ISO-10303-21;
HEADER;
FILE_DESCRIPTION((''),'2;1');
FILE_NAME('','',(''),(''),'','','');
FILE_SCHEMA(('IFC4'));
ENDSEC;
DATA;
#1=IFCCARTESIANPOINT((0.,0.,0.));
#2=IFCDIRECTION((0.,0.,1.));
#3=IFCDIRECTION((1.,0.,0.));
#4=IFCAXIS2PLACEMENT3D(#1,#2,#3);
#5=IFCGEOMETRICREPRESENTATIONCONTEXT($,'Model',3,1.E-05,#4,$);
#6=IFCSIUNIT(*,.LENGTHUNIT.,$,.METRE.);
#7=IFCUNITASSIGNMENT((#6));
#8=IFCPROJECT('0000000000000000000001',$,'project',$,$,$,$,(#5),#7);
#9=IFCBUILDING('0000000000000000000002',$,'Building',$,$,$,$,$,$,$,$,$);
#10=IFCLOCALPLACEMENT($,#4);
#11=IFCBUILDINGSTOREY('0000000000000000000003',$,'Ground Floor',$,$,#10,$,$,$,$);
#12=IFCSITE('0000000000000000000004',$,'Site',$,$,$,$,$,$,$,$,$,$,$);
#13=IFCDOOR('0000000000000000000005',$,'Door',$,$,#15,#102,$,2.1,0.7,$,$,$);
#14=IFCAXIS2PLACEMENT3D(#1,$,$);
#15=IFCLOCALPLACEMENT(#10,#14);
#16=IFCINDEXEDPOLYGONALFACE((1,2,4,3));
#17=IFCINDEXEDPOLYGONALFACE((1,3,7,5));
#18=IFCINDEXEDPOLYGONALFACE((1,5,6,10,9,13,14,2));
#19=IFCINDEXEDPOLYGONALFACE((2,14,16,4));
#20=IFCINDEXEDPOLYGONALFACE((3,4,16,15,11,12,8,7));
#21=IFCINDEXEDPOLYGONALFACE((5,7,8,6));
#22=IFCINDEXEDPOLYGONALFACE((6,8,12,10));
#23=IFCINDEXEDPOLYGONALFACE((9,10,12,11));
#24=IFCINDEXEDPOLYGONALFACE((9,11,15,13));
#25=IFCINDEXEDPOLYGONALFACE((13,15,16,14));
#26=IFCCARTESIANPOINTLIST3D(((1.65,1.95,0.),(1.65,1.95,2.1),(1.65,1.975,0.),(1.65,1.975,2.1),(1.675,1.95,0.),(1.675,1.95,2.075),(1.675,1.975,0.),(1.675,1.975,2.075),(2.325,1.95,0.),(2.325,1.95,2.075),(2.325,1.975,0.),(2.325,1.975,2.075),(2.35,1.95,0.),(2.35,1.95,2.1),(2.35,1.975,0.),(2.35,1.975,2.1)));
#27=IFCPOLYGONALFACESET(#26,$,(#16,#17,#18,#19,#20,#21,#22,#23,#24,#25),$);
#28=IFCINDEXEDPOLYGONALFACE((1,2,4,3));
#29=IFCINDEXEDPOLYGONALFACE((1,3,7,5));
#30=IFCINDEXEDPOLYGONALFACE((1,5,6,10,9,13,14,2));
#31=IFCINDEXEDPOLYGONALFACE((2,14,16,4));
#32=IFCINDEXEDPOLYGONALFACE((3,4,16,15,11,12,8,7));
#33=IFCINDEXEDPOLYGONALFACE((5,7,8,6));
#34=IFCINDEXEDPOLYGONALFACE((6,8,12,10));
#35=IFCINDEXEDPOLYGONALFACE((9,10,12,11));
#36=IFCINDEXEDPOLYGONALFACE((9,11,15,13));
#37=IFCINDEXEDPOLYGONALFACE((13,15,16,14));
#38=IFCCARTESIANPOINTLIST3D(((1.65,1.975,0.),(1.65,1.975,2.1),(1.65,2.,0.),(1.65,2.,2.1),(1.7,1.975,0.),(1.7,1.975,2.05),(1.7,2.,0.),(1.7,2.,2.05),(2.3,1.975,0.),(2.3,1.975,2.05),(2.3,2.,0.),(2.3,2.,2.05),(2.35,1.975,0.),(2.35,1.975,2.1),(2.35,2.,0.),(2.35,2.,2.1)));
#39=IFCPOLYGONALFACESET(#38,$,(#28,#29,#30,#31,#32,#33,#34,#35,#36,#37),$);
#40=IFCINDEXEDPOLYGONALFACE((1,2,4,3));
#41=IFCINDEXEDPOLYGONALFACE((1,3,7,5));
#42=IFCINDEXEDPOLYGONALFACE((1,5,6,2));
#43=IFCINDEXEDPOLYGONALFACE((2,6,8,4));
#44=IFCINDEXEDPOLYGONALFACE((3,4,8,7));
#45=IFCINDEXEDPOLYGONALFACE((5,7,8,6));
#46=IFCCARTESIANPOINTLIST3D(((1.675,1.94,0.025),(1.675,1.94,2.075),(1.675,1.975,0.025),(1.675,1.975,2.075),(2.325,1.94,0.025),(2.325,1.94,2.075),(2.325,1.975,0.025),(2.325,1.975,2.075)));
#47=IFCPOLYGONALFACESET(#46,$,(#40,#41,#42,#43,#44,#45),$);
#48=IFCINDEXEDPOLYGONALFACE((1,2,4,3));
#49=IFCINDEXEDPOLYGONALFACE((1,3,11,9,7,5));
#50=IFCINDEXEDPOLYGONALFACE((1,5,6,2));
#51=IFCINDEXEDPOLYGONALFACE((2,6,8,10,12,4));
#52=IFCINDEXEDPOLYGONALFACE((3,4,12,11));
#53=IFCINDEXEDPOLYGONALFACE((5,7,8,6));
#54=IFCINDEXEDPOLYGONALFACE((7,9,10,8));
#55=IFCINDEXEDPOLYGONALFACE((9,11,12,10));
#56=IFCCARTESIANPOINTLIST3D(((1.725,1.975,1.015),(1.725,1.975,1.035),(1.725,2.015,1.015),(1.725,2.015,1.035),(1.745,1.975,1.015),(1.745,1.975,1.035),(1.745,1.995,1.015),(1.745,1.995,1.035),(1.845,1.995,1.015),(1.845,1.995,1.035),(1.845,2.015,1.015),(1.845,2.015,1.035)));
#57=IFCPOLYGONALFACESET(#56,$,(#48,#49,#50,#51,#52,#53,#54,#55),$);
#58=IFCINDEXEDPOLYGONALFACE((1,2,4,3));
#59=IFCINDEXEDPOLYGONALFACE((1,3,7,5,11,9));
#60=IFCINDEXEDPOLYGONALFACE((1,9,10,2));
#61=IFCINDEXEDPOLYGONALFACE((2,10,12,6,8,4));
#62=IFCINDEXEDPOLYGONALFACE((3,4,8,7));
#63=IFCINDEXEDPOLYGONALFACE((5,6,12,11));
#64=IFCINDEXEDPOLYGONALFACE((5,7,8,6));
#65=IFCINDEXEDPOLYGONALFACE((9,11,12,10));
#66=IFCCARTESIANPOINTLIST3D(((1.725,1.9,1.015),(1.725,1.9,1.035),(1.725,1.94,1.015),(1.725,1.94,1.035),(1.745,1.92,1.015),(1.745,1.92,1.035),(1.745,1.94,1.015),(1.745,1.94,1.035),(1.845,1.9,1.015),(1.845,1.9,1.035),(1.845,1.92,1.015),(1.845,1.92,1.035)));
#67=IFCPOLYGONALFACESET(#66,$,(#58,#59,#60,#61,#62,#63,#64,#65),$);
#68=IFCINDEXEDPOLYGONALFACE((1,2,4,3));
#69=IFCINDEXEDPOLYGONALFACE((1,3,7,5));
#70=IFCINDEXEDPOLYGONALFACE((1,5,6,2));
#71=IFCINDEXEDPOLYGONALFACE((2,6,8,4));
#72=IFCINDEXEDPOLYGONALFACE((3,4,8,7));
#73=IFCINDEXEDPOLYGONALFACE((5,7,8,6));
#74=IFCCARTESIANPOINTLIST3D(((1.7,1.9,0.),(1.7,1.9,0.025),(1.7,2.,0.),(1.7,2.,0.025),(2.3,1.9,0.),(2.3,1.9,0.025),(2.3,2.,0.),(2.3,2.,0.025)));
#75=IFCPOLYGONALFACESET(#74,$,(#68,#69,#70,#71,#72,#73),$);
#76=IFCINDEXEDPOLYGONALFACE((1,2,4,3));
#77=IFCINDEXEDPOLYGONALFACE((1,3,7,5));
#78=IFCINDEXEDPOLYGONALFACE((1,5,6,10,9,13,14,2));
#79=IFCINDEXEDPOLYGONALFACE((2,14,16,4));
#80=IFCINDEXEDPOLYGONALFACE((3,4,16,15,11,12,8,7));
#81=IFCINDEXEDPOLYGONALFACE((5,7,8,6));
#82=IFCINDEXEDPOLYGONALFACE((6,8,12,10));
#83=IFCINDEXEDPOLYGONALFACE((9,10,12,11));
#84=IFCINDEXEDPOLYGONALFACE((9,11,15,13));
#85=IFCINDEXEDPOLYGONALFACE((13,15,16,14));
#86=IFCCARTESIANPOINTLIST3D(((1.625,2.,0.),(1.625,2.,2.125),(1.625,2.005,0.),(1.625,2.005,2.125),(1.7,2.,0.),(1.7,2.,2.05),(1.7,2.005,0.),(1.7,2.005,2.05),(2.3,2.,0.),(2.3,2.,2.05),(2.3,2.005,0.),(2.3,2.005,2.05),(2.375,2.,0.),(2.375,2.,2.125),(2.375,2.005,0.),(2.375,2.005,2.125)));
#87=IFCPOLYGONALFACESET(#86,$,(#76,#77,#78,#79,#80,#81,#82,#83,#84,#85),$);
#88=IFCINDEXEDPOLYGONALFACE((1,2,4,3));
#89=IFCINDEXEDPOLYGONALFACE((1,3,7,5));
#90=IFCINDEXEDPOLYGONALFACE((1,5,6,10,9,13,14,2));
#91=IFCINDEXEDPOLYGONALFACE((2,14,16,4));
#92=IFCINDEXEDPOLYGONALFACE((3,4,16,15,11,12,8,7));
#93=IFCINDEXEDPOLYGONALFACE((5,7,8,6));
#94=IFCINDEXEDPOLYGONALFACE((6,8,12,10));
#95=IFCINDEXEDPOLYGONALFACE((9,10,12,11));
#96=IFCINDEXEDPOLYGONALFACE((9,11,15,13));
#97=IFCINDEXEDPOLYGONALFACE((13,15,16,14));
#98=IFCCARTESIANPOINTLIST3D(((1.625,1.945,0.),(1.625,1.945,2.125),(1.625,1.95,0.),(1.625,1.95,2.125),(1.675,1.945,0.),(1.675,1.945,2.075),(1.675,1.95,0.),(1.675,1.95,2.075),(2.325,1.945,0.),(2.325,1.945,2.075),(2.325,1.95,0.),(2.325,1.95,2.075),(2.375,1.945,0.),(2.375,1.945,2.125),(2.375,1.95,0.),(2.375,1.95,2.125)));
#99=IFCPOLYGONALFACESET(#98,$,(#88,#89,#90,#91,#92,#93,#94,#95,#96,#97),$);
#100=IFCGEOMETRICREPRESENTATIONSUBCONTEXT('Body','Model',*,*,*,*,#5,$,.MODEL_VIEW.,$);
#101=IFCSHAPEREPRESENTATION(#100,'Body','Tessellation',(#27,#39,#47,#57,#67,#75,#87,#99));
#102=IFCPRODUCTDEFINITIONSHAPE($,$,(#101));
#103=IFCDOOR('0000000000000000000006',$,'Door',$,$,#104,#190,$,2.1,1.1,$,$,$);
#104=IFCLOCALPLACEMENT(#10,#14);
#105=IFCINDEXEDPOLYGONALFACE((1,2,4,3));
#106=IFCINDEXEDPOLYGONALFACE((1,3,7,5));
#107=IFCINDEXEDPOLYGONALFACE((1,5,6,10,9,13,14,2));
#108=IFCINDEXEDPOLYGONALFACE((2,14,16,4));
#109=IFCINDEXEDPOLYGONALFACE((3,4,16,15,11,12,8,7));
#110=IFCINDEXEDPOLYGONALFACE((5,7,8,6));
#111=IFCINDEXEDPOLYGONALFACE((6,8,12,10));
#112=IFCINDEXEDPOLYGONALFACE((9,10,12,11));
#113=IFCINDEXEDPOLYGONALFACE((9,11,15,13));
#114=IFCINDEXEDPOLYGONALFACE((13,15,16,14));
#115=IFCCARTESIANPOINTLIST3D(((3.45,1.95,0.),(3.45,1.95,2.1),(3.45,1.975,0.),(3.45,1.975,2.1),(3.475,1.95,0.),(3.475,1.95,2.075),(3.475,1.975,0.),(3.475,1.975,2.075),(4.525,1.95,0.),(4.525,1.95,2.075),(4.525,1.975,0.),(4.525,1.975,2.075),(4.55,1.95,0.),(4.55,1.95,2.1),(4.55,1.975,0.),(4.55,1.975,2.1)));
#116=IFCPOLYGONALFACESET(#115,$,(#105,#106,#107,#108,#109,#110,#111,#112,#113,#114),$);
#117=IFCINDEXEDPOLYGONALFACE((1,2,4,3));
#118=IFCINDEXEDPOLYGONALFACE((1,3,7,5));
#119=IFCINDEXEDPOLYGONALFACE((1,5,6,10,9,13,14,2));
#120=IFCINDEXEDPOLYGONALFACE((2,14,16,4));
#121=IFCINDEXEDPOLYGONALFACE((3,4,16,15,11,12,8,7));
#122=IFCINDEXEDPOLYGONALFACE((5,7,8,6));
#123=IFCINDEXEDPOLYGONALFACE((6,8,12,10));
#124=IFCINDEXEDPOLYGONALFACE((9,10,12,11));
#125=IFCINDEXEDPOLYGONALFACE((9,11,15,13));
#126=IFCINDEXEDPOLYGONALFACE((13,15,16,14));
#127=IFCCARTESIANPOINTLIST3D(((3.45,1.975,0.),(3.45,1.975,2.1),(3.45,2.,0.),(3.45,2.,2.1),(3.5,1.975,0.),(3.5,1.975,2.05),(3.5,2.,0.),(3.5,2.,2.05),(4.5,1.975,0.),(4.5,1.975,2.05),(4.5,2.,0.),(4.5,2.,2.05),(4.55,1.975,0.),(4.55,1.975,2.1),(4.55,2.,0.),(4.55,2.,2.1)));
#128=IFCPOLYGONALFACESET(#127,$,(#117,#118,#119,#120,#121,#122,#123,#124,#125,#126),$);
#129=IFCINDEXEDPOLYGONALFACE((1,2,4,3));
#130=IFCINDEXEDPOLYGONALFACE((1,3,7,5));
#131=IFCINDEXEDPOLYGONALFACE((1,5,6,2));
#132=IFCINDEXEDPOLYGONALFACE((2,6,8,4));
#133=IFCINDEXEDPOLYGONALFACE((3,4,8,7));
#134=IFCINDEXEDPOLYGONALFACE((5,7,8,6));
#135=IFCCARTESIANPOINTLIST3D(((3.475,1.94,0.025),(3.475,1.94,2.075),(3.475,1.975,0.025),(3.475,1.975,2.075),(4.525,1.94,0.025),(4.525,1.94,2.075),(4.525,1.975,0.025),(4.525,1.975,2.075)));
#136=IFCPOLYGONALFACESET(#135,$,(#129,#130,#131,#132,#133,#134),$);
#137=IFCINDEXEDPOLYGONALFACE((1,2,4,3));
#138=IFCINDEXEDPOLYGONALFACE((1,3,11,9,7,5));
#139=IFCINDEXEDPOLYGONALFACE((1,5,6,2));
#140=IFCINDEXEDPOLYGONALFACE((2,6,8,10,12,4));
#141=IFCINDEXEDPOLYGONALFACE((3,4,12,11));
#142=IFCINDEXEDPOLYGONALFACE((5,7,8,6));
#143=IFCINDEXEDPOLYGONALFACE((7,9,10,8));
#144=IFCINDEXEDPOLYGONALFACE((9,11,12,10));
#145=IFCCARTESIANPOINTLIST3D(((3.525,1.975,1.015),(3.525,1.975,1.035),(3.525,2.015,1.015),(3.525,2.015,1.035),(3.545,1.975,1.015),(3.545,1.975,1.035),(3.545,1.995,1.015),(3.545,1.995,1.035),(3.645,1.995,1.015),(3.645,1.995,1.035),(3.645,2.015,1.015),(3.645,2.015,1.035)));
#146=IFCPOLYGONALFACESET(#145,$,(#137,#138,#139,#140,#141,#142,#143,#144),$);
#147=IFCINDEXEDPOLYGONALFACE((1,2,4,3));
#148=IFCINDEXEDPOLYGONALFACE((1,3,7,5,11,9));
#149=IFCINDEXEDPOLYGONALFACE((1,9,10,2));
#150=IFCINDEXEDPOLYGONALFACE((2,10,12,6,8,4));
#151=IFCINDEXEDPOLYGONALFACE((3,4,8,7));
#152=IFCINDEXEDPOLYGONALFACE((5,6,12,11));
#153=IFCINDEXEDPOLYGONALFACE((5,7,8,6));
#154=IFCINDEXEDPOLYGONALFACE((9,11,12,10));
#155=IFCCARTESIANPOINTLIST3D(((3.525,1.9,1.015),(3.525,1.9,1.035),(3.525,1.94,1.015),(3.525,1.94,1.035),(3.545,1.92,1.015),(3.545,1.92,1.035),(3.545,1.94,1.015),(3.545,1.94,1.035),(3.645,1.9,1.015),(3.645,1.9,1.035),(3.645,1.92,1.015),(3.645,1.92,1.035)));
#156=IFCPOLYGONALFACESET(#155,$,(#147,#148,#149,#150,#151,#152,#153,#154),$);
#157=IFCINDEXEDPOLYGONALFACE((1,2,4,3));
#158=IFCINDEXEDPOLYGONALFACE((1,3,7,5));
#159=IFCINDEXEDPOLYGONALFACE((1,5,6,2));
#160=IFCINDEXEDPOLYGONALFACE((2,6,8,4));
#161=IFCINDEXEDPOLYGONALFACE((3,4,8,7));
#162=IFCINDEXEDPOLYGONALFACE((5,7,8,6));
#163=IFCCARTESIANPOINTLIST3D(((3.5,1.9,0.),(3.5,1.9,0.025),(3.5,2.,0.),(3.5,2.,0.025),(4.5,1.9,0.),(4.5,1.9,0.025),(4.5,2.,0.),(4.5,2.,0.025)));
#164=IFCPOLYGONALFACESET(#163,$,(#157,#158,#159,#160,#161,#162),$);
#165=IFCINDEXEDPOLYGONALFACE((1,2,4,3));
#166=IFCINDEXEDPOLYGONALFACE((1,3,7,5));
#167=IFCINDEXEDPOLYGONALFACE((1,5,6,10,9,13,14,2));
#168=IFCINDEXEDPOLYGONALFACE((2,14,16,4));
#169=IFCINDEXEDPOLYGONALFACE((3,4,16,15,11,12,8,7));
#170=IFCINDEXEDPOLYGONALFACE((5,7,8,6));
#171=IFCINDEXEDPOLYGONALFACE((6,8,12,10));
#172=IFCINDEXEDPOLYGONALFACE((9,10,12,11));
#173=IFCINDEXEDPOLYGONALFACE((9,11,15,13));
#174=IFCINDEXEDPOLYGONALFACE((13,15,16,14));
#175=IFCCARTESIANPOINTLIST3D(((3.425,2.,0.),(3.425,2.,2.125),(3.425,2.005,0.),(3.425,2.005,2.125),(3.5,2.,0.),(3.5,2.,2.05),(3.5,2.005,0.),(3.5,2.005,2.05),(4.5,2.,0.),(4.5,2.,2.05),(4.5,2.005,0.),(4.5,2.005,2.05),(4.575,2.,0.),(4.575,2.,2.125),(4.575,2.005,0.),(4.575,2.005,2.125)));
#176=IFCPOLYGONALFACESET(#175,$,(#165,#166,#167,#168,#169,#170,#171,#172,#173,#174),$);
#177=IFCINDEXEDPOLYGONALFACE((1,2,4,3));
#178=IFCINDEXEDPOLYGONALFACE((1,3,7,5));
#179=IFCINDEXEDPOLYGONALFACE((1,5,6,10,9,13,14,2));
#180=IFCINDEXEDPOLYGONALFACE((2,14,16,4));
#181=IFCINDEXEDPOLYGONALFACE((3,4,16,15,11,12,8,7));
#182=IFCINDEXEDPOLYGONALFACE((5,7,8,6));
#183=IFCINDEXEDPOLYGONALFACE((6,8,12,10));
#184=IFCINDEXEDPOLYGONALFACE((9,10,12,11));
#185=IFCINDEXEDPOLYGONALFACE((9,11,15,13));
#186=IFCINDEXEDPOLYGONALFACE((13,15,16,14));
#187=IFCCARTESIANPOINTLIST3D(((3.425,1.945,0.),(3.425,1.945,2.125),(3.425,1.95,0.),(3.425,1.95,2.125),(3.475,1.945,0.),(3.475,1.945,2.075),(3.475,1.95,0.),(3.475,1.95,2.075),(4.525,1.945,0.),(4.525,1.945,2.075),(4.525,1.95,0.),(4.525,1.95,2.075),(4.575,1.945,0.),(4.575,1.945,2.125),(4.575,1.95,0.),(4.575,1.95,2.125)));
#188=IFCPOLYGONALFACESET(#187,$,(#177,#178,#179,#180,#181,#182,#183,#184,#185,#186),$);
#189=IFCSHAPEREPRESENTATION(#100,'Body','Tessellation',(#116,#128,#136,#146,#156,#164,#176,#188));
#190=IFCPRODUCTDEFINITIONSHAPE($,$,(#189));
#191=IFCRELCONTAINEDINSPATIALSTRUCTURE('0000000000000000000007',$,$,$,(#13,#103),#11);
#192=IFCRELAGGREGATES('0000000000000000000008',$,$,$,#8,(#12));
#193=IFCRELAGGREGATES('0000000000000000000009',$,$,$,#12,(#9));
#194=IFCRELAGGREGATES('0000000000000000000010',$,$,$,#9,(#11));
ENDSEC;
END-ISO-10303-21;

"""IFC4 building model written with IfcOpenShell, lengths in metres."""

from ifc_helpers import new_model, si_unit, frame, origin_with_axes, place, context, subcontext, project, spatial, line, indexed_curve, outline, extrude, element, save


model = new_model("IFC4")

# Units and contexts
model_context = context("Model", 3, precision=1e-05, world=origin_with_axes())
body_context = subcontext(model_context, "Body", "Model", "MODEL_VIEW")
ifc_project = project(units=[si_unit("LENGTHUNIT", "METRE")], contexts=[model_context])

# Site, building, storey
site = spatial("IfcSite", under=ifc_project, Name="Site")
building = spatial("IfcBuilding", under=site, Name="Building")
storey_placement = place(None, origin_with_axes())
storey = spatial("IfcBuildingStorey", under=building, at=storey_placement, Name="Ground Floor")

# Doors
door_1_placement = place(storey_placement, frame((2.35, 2.0, 0.0), z_axis=(0.0, 0.0, 1.0), x_axis=(-1.0, 0.0, 0.0)))
element("IfcDoor", 1, at=door_1_placement, inside=storey, Name="Door", OverallHeight=2.1, OverallWidth=0.7, context=body_context, shape_type="SweptSolid", body=[
    extrude(outline(indexed_curve([(0.0, 0.0), (0.0, 2.1), (0.7, 2.1), (0.7, 0.0), (0.675, 0.0), (0.675, 2.075), (0.025, 2.075), (0.025, 0.0)], segments=[line(1, 2, 3, 4, 5, 6, 7, 8, 1)])), frame((0.0, 0.025, 0.0), z_axis=(0.0, -1.0, 0.0), x_axis=(1.0, 0.0, 0.0)), (0.0, 0.0, -1.0), 0.025),
    extrude(outline(indexed_curve([(0.0, 0.0), (0.0, 2.1), (0.7, 2.1), (0.7, 0.0), (0.65, 0.0), (0.65, 2.05), (0.05, 2.05), (0.05, 0.0)], segments=[line(1, 2, 3, 4, 5, 6, 7, 8, 1)])), frame((0.0, 0.0, 0.0), z_axis=(0.0, -1.0, 0.0), x_axis=(1.0, 0.0, 0.0)), (0.0, 0.0, -1.0), 0.025),
    extrude(outline(indexed_curve([(0.0, 0.0), (0.65, 0.0), (0.65, 0.035), (0.0, 0.035)], segments=[line(1, 2, 3, 4, 1)])), frame((0.025, 0.025, 0.025), z_axis=(0.0, 0.0, 1.0), x_axis=(1.0, 0.0, 0.0)), (0.0, 0.0, 1.0), 2.05),
    extrude(outline(indexed_curve([(0.0, 0.0), (0.0, -0.04), (-0.12, -0.04), (-0.12, -0.02), (-0.02, -0.02), (-0.02, 0.0)], segments=[line(1, 2, 3, 4, 5, 6, 1)])), frame((0.625, 0.025, 1.015), z_axis=(0.0, 0.0, 1.0), x_axis=(1.0, 0.0, 0.0)), (0.0, 0.0, 1.0), 0.02),
    extrude(outline(indexed_curve([(0.0, 0.0), (0.0, 0.04), (-0.12, 0.04), (-0.12, 0.02), (-0.02, 0.02), (-0.02, 0.0)], segments=[line(1, 2, 3, 4, 5, 6, 1)])), frame((0.625, 0.06, 1.015), z_axis=(0.0, 0.0, 1.0), x_axis=(1.0, 0.0, 0.0)), (0.0, 0.0, 1.0), 0.02),
    extrude(outline(indexed_curve([(0.0, 0.0), (0.6, 0.0), (0.6, 0.1), (0.0, 0.1)], segments=[line(1, 2, 3, 4, 1)])), frame((0.05, 0.0, 0.0), z_axis=(0.0, 0.0, 1.0), x_axis=(1.0, 0.0, 0.0)), (0.0, 0.0, 1.0), 0.025),
    extrude(outline(indexed_curve([(0.0, 0.0), (0.0, 2.125), (0.75, 2.125), (0.75, 0.0), (0.675, 0.0), (0.675, 2.05), (0.075, 2.05), (0.075, 0.0)], segments=[line(1, 2, 3, 4, 5, 6, 7, 8, 1)])), frame((-0.025, -0.005, 0.0), z_axis=(0.0, -1.0, 0.0), x_axis=(1.0, 0.0, 0.0)), (0.0, 0.0, -1.0), 0.005),
    extrude(outline(indexed_curve([(0.0, 0.0), (0.0, 2.125), (0.75, 2.125), (0.75, 0.0), (0.7, 0.0), (0.7, 2.075), (0.05, 2.075), (0.05, 0.0)], segments=[line(1, 2, 3, 4, 5, 6, 7, 8, 1)])), frame((-0.025, 0.05, 0.0), z_axis=(0.0, -1.0, 0.0), x_axis=(1.0, 0.0, 0.0)), (0.0, 0.0, -1.0), 0.005),
])
door_2_placement = place(storey_placement, frame((4.55, 2.0, 0.0), z_axis=(0.0, 0.0, 1.0), x_axis=(-1.0, 0.0, 0.0)))
element("IfcDoor", 2, at=door_2_placement, inside=storey, Name="Door", OverallHeight=2.1, OverallWidth=1.1, context=body_context, shape_type="SweptSolid", body=[
    extrude(outline(indexed_curve([(0.0, 0.0), (0.0, 2.1), (1.1, 2.1), (1.1, 0.0), (1.075, 0.0), (1.075, 2.075), (0.025, 2.075), (0.025, 0.0)], segments=[line(1, 2, 3, 4, 5, 6, 7, 8, 1)])), frame((0.0, 0.025, 0.0), z_axis=(0.0, -1.0, 0.0), x_axis=(1.0, 0.0, 0.0)), (0.0, 0.0, -1.0), 0.025),
    extrude(outline(indexed_curve([(0.0, 0.0), (0.0, 2.1), (1.1, 2.1), (1.1, 0.0), (1.05, 0.0), (1.05, 2.05), (0.05, 2.05), (0.05, 0.0)], segments=[line(1, 2, 3, 4, 5, 6, 7, 8, 1)])), frame((0.0, 0.0, 0.0), z_axis=(0.0, -1.0, 0.0), x_axis=(1.0, 0.0, 0.0)), (0.0, 0.0, -1.0), 0.025),
    extrude(outline(indexed_curve([(0.0, 0.0), (1.05, 0.0), (1.05, 0.035), (0.0, 0.035)], segments=[line(1, 2, 3, 4, 1)])), frame((0.025, 0.025, 0.025), z_axis=(0.0, 0.0, 1.0), x_axis=(1.0, 0.0, 0.0)), (0.0, 0.0, 1.0), 2.05),
    extrude(outline(indexed_curve([(0.0, 0.0), (0.0, -0.04), (-0.12, -0.04), (-0.12, -0.02), (-0.02, -0.02), (-0.02, 0.0)], segments=[line(1, 2, 3, 4, 5, 6, 1)])), frame((1.025, 0.025, 1.015), z_axis=(0.0, 0.0, 1.0), x_axis=(1.0, 0.0, 0.0)), (0.0, 0.0, 1.0), 0.02),
    extrude(outline(indexed_curve([(0.0, 0.0), (0.0, 0.04), (-0.12, 0.04), (-0.12, 0.02), (-0.02, 0.02), (-0.02, 0.0)], segments=[line(1, 2, 3, 4, 5, 6, 1)])), frame((1.025, 0.06, 1.015), z_axis=(0.0, 0.0, 1.0), x_axis=(1.0, 0.0, 0.0)), (0.0, 0.0, 1.0), 0.02),
    extrude(outline(indexed_curve([(0.0, 0.0), (1.0, 0.0), (1.0, 0.1), (0.0, 0.1)], segments=[line(1, 2, 3, 4, 1)])), frame((0.05, 0.0, 0.0), z_axis=(0.0, 0.0, 1.0), x_axis=(1.0, 0.0, 0.0)), (0.0, 0.0, 1.0), 0.025),
    extrude(outline(indexed_curve([(0.0, 0.0), (0.0, 2.125), (1.15, 2.125), (1.15, 0.0), (1.075, 0.0), (1.075, 2.05), (0.075, 2.05), (0.075, 0.0)], segments=[line(1, 2, 3, 4, 5, 6, 7, 8, 1)])), frame((-0.025, -0.005, 0.0), z_axis=(0.0, -1.0, 0.0), x_axis=(1.0, 0.0, 0.0)), (0.0, 0.0, -1.0), 0.005),
    extrude(outline(indexed_curve([(0.0, 0.0), (0.0, 2.125), (1.15, 2.125), (1.15, 0.0), (1.1, 0.0), (1.1, 2.075), (0.05, 2.075), (0.05, 0.0)], segments=[line(1, 2, 3, 4, 5, 6, 7, 8, 1)])), frame((-0.025, 0.05, 0.0), z_axis=(0.0, -1.0, 0.0), x_axis=(1.0, 0.0, 0.0)), (0.0, 0.0, -1.0), 0.005),
])

save(model, "model.ifc")
